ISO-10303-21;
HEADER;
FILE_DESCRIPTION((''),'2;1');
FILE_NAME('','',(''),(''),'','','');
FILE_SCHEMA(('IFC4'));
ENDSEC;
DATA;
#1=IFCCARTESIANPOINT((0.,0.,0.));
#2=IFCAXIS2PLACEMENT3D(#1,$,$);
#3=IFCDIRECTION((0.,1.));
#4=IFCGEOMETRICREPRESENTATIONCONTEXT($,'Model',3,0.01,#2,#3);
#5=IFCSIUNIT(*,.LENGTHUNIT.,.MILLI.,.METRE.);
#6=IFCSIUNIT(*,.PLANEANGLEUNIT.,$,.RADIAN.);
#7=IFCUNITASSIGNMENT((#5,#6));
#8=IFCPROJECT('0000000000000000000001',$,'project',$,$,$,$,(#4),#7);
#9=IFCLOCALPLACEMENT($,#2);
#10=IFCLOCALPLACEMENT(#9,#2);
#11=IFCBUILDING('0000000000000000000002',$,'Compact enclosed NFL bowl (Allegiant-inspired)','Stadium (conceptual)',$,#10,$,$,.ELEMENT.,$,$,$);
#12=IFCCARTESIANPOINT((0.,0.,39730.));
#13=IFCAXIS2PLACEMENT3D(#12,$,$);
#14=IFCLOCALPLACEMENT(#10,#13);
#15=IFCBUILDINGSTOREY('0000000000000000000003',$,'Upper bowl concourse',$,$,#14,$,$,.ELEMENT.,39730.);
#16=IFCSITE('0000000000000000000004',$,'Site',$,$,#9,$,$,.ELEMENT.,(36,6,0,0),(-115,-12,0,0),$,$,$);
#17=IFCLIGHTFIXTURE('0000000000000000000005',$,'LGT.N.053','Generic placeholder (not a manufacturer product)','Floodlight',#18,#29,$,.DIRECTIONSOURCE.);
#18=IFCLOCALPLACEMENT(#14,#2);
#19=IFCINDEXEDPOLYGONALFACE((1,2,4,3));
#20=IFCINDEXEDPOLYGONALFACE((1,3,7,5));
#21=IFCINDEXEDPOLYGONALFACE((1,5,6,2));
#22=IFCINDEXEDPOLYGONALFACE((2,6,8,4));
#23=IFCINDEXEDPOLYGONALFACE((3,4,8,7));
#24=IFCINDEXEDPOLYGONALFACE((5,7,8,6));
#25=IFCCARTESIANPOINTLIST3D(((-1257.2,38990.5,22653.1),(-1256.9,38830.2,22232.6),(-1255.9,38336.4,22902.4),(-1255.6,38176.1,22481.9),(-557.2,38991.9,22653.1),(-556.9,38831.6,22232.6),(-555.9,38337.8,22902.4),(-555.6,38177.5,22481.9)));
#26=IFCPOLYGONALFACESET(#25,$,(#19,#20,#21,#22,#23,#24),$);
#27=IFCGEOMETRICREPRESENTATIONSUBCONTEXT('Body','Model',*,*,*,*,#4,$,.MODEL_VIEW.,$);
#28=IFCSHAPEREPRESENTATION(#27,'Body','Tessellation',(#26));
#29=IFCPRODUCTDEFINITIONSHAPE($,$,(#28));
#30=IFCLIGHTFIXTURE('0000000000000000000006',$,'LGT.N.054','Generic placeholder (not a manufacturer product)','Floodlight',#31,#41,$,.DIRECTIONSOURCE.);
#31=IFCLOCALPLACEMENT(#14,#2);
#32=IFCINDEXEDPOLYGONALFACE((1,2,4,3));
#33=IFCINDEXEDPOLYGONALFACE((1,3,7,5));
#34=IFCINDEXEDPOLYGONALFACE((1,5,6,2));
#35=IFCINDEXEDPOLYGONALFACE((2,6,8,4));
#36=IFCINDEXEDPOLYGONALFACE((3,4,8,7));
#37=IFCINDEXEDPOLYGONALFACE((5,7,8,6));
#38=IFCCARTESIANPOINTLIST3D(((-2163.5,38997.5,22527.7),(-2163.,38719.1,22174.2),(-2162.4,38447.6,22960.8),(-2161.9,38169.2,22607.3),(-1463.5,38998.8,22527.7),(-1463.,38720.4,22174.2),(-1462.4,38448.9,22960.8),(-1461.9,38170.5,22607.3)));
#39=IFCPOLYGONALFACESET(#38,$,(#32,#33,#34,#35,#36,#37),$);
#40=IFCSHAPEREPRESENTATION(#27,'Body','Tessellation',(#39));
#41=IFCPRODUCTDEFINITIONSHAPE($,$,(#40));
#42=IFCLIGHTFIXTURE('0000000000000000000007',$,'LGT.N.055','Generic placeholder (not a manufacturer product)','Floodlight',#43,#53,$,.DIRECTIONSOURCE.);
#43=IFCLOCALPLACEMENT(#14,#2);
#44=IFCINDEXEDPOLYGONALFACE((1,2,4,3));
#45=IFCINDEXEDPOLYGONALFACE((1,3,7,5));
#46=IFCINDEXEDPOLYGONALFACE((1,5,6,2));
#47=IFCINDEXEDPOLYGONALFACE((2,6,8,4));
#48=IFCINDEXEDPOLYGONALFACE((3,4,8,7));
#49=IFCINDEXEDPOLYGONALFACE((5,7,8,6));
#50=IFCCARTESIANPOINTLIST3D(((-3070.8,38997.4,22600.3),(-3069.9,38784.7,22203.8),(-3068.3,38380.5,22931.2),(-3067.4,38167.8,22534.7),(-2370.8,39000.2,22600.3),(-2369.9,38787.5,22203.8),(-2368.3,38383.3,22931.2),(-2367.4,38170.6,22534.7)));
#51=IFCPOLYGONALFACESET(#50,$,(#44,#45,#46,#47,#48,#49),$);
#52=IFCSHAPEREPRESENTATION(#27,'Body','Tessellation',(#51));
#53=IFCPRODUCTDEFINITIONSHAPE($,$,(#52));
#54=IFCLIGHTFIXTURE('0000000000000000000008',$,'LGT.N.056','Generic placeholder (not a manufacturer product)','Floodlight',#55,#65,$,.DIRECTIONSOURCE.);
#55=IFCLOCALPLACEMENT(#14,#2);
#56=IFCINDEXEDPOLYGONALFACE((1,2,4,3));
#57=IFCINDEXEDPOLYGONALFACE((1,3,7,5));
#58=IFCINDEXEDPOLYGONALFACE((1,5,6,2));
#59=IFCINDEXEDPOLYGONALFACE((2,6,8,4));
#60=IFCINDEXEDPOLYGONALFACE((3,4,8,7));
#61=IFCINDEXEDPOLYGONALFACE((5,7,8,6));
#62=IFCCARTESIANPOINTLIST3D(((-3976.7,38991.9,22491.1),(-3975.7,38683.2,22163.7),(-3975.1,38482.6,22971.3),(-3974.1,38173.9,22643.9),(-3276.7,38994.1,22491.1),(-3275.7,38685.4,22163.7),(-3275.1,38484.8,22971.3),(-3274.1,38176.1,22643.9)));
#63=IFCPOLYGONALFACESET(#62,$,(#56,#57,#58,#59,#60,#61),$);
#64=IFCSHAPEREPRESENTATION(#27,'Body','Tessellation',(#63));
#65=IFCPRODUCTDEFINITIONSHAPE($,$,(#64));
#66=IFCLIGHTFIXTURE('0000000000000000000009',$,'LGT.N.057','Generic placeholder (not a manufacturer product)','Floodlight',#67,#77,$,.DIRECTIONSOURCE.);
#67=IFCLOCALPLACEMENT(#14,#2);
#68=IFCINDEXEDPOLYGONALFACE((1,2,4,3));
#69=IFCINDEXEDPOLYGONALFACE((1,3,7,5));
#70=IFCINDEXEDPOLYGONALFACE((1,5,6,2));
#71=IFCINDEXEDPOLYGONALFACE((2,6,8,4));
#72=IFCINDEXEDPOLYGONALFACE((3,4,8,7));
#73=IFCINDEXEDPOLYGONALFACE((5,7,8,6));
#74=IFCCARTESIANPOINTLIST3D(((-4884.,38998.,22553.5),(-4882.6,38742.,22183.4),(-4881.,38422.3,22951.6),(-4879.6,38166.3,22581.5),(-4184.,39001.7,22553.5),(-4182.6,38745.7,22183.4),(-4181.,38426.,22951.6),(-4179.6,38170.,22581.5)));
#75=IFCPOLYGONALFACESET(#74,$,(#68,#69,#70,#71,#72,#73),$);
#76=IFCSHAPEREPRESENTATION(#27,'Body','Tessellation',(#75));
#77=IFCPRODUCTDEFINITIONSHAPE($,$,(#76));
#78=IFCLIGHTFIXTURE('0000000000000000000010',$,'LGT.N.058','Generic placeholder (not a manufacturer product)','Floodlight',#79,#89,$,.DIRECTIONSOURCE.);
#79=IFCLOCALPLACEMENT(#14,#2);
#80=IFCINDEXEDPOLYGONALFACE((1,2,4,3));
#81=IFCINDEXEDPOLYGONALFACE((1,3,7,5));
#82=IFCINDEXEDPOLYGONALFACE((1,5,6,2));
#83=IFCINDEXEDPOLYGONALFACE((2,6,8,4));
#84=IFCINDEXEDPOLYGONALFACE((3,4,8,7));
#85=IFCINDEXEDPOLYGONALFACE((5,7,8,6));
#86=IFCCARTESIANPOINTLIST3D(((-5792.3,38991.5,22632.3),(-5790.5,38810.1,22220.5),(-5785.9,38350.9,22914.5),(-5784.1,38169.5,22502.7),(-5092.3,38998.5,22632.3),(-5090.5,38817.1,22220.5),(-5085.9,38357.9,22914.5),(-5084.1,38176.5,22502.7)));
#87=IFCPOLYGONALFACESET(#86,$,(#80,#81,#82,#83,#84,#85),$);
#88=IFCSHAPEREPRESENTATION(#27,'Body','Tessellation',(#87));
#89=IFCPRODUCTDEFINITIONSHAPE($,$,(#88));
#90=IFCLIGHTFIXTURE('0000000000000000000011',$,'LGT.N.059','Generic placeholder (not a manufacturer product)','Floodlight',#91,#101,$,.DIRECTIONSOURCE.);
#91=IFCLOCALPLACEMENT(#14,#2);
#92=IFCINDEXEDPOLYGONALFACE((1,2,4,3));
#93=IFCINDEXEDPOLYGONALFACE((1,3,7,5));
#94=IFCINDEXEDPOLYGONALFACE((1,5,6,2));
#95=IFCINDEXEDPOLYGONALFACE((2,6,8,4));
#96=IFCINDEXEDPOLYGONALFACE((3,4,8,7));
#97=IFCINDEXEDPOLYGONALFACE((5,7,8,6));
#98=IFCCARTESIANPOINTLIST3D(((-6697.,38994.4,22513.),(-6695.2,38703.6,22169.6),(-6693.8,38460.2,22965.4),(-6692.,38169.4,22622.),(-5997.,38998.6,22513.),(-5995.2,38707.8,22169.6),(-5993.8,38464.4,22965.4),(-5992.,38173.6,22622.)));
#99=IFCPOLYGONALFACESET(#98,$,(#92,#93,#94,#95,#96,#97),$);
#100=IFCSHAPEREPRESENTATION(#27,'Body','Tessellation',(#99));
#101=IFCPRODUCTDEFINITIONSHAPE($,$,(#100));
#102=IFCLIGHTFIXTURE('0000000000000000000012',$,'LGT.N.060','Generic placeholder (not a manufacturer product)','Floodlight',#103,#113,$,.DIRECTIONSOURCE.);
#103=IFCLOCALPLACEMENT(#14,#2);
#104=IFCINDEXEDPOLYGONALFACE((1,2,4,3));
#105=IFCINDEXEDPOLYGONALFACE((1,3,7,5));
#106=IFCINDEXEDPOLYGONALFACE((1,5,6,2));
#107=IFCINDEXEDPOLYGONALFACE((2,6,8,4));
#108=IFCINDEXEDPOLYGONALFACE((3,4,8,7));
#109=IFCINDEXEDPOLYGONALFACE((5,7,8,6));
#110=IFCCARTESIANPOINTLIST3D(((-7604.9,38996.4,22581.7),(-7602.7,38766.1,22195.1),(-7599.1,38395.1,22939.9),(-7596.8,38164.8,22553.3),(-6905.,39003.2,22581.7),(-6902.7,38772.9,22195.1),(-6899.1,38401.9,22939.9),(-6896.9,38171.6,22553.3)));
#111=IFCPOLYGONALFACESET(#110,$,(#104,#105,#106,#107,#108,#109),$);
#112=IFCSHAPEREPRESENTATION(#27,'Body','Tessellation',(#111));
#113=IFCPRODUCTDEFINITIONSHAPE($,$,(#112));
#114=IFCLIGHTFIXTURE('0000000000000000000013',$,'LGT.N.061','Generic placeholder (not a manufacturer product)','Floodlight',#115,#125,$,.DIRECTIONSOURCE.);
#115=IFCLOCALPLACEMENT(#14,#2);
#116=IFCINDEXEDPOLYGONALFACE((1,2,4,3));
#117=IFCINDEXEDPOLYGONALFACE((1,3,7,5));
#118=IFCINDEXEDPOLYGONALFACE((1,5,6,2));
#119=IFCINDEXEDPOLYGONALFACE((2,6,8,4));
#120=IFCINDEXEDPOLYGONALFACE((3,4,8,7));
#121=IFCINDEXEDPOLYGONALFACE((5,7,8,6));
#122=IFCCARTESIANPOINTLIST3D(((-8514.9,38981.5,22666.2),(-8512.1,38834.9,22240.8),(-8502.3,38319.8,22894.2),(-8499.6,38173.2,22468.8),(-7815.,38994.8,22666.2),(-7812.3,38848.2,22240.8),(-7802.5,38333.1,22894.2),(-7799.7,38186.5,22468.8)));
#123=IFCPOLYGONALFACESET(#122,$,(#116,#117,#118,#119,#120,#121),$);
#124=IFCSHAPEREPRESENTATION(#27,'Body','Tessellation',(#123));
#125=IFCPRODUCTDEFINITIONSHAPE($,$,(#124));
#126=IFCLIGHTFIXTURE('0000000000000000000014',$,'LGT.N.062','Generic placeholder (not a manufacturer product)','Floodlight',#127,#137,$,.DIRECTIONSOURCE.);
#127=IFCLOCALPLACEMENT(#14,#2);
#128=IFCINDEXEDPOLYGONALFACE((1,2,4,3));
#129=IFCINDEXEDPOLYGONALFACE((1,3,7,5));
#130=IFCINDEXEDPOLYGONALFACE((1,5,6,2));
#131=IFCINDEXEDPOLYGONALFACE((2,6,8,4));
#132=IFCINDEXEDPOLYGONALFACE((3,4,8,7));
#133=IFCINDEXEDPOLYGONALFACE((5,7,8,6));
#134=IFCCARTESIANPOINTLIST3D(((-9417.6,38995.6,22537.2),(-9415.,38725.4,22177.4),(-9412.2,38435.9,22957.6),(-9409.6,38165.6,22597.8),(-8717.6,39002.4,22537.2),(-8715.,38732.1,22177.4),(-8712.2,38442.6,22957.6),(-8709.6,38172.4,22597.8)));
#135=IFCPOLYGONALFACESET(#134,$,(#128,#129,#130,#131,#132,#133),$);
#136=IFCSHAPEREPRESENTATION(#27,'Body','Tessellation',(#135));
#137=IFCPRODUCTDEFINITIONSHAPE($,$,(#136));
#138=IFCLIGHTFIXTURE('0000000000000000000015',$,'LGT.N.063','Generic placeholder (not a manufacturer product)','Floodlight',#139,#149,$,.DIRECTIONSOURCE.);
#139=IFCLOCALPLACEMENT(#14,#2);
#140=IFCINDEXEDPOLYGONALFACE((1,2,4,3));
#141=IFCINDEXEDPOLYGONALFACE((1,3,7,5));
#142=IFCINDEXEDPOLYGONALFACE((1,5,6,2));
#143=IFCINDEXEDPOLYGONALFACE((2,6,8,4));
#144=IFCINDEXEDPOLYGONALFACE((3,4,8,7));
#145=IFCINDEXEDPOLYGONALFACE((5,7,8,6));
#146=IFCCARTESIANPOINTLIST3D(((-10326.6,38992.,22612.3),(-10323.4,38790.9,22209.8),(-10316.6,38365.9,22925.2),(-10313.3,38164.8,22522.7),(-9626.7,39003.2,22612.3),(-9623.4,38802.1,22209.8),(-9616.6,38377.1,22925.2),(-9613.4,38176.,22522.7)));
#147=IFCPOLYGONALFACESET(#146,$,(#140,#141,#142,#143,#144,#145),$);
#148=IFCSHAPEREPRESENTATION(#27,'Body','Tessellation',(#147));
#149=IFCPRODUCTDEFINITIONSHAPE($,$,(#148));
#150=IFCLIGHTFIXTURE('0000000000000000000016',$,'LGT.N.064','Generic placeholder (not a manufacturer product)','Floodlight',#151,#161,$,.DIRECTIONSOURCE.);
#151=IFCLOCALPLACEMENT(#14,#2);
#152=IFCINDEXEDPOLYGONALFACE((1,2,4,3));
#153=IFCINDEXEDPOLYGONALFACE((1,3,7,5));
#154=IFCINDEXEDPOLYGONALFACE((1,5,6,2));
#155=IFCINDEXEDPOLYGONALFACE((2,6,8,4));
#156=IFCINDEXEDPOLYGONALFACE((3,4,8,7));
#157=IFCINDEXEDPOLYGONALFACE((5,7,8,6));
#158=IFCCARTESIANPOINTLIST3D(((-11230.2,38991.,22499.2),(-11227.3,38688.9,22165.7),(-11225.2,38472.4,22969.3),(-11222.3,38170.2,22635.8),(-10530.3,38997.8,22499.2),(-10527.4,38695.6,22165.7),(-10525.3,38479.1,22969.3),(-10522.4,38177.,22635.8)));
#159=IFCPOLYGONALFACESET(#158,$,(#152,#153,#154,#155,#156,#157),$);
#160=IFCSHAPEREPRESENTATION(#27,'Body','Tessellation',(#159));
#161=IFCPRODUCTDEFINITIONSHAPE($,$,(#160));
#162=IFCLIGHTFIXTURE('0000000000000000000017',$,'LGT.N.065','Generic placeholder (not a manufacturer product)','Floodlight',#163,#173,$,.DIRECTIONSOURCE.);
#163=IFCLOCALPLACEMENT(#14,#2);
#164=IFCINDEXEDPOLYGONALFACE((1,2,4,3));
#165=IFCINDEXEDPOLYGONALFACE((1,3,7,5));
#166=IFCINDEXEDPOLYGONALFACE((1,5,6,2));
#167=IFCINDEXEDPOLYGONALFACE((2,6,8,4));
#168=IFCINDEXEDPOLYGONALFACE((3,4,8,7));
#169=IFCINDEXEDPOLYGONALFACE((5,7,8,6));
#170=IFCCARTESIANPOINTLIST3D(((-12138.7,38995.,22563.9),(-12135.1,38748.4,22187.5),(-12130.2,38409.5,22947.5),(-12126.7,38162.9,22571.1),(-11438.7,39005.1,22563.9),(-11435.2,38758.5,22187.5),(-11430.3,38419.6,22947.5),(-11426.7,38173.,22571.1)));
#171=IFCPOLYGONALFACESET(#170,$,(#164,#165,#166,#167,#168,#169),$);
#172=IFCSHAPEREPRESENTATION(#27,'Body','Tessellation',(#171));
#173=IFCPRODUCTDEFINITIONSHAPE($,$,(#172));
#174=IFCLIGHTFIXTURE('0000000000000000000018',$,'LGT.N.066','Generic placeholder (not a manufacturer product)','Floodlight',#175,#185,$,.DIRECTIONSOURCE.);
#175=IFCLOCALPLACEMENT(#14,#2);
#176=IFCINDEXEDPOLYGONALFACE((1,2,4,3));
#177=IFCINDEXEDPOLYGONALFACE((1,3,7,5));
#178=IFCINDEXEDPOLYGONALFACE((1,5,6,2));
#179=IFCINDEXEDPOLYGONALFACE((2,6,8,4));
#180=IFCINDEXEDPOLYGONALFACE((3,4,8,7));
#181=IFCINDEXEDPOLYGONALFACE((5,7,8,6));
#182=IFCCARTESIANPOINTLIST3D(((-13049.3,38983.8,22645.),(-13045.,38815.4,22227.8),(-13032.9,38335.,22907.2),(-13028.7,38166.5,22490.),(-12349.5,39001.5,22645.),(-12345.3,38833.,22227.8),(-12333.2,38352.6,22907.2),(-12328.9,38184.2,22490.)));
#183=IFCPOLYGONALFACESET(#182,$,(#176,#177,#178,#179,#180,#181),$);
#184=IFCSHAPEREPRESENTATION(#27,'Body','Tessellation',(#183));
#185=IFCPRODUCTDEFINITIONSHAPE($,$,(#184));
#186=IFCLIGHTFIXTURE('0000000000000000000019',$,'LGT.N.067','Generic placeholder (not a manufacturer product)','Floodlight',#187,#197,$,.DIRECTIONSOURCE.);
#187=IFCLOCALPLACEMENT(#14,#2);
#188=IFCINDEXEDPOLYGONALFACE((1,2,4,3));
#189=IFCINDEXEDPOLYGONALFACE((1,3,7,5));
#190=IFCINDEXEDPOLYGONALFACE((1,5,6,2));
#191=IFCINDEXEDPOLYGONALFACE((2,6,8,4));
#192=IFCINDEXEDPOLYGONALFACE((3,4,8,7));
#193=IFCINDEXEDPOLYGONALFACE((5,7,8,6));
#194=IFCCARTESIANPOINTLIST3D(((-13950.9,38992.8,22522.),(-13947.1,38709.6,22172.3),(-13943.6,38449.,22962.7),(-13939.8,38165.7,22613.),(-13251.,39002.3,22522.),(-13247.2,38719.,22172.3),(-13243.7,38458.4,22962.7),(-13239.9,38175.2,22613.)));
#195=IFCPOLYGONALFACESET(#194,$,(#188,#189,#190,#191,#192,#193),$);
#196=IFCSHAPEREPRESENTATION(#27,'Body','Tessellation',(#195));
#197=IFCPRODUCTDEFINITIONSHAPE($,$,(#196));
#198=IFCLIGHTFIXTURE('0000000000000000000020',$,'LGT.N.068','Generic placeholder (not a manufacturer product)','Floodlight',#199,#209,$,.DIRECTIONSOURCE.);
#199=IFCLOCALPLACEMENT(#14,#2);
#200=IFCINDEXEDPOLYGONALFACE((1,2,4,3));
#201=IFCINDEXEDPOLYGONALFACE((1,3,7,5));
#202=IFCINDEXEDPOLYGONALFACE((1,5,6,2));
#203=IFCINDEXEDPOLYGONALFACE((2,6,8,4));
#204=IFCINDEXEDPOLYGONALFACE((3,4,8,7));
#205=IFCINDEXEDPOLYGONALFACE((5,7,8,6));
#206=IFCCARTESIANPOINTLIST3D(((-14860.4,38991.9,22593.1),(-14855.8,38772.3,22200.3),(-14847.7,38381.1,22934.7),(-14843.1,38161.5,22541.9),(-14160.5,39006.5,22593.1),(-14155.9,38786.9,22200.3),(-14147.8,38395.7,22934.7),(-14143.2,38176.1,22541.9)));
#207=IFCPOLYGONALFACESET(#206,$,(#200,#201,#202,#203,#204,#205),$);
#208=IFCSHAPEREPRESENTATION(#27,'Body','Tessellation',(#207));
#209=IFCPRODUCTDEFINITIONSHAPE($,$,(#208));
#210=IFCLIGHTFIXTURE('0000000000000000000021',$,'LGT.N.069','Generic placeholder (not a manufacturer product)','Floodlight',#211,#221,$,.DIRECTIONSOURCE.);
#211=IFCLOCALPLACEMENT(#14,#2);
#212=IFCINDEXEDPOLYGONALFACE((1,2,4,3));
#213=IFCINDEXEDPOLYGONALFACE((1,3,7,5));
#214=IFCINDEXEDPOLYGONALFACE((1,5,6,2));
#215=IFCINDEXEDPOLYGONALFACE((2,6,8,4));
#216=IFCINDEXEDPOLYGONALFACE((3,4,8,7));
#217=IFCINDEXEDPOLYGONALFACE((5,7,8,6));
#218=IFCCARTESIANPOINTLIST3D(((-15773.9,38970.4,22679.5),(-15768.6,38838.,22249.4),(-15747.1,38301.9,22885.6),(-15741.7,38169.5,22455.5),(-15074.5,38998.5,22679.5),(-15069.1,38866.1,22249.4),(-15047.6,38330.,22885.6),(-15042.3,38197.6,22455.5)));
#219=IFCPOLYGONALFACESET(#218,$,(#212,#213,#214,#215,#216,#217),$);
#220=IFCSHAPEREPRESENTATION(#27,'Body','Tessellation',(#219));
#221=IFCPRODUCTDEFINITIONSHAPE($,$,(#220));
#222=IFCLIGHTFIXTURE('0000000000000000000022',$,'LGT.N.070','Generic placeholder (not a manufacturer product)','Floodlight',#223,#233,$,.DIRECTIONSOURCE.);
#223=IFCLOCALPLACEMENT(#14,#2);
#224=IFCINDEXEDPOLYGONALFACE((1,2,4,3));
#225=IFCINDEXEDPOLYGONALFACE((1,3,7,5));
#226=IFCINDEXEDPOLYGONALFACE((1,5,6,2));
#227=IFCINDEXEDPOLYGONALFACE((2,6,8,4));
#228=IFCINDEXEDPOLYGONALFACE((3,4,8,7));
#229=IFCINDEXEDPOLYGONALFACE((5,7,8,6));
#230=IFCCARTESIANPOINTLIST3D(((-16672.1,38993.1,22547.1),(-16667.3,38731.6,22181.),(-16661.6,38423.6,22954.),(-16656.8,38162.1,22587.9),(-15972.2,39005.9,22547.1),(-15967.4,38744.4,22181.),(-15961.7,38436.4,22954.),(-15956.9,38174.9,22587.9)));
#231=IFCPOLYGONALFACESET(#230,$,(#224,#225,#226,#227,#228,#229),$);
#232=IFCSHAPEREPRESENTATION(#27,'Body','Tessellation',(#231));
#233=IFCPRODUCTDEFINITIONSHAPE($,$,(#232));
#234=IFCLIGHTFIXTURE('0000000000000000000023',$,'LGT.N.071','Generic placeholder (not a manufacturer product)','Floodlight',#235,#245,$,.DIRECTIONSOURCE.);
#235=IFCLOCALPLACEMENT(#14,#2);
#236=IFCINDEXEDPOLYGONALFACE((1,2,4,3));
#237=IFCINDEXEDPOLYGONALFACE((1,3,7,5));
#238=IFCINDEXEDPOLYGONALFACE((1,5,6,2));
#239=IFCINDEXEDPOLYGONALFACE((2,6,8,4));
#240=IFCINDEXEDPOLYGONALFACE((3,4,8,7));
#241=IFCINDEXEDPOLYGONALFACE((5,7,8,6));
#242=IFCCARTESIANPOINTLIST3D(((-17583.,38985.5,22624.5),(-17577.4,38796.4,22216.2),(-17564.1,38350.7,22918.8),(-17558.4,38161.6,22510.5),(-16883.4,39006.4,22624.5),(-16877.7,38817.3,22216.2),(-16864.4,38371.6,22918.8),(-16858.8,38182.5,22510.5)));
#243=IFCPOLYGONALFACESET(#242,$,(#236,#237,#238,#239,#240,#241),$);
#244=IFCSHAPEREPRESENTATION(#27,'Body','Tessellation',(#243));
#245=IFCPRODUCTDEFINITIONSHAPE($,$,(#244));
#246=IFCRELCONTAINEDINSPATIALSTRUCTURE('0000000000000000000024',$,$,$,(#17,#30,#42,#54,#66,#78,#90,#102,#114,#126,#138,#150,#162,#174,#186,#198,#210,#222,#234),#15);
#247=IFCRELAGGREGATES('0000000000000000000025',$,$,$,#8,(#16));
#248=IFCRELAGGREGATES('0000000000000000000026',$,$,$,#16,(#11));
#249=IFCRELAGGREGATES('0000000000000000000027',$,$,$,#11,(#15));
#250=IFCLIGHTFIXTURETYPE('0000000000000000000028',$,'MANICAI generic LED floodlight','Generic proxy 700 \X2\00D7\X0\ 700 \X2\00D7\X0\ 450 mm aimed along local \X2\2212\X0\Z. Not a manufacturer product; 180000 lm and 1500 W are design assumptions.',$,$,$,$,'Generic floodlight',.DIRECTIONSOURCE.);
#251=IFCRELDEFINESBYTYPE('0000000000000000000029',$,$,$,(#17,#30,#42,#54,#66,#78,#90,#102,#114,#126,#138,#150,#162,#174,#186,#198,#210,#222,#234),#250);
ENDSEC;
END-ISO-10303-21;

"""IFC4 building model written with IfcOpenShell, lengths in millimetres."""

from ifc_helpers import new_model, si_unit, direction, frame, origin, place, context, subcontext, project, spatial, rectangle, extrude, source, transform, mapped, type_object, type_shapes, element, save


model = new_model("IFC4")

# Units and contexts
model_context = context("Model", 3, precision=0.01, world=origin(), true_north=direction((0.0, 1.0)))
body_context = subcontext(model_context, "Body", "Model", "MODEL_VIEW")
ifc_project = project(units=[si_unit("LENGTHUNIT", "METRE", prefix="MILLI"), si_unit("PLANEANGLEUNIT", "RADIAN")], contexts=[model_context])

# Site, building, storey
site_placement = place(None, origin())
site = spatial("IfcSite", under=ifc_project, at=site_placement, Name="Site", CompositionType="ELEMENT", RefLatitude=(36, 6, 0, 0), RefLongitude=(-115, -12, 0, 0))
building_placement = place(site_placement, origin())
building = spatial("IfcBuilding", under=site, at=building_placement, Name="Compact enclosed NFL bowl (Allegiant-inspired)", Description="Stadium (conceptual)", CompositionType="ELEMENT")
storey_placement = place(building_placement, frame((0.0, 0.0, 39730.0)))
storey = spatial("IfcBuildingStorey", under=building, at=storey_placement, Name="Upper bowl concourse", CompositionType="ELEMENT", Elevation=39730.0)

# Light fixtures
light_fixture_type = type_object("IfcLightFixtureType", Name="MANICAI generic LED floodlight", Description="Generic proxy 700 × 700 × 450 mm aimed along local −Z. Not a manufacturer product; 180000 lm and 1500 W are design assumptions.", ElementType="Generic floodlight", PredefinedType="DIRECTIONSOURCE")
shared_shape = source(origin(), body_context, "Body", "SweptSolid", [
    extrude(rectangle(XDim=700.0, YDim=700.0), frame((0.0, 0.0, -225.0)), (0.0, 0.0, 1.0), 450.0),
])
type_shapes(light_fixture_type, [shared_shape])
for number, where, z_axis, x_axis, name in (
    (1, (-906.4, 38584.0, 22567.5), (-0.00068, 0.356162, 0.934424), (-0.999998, -0.001909, 0.0), "LGT.N.053"),
    (2, (-1812.7, 38584.0, 22567.5), (-0.001143, 0.618717, 0.785613), (-0.999998, -0.001847, 0.0), "LGT.N.054"),
    (3, (-2719.1, 38584.0, 22567.5), (-0.001923, 0.472682, 0.881231), (-0.999992, -0.004069, 0.0), "LGT.N.055"),
    (4, (-3625.4, 38584.0, 22567.5), (-0.002117, 0.685986, 0.727612), (-0.999995, -0.003086, 0.0), "LGT.N.056"),
    (5, (-4531.8, 38584.0, 22567.5), (-0.002991, 0.568825, 0.822453), (-0.999986, -0.005259, 0.0), "LGT.N.057"),
    (6, (-5438.2, 38584.0, 22567.5), (-0.003994, 0.40308, 0.915156), (-0.999951, -0.009909, 0.0), "LGT.N.058"),
    (7, (-6344.5, 38584.0, 22567.5), (-0.003886, 0.646248, 0.763118), (-0.999982, -0.006013, 0.0), "LGT.N.059"),
    (8, (-7250.9, 38584.0, 22567.5), (-0.005, 0.511759, 0.859115), (-0.999952, -0.009769, 0.0), "LGT.N.060"),
    (9, (-8157.3, 38584.0, 22567.5), (-0.00619, 0.325717, 0.945447), (-0.999819, -0.019, 0.0), "LGT.N.061"),
    (10, (-9063.6, 38584.0, 22567.5), (-0.005817, 0.600457, 0.799636), (-0.999953, -0.009687, 0.0), "LGT.N.062"),
    (11, (-9970.0, 38584.0, 22567.5), (-0.007158, 0.447018, 0.894496), (-0.999872, -0.01601, 0.0), "LGT.N.063"),
    (12, (-10876.3, 38584.0, 22567.5), (-0.006469, 0.671463, 0.74101), (-0.999954, -0.009633, 0.0), "LGT.N.064"),
    (13, (-11782.7, 38584.0, 22567.5), (-0.007911, 0.547894, 0.836511), (-0.999896, -0.014437, 0.0), "LGT.N.065"),
    (14, (-12689.1, 38584.0, 22567.5), (-0.009443, 0.374413, 0.927214), (-0.999682, -0.025213, 0.0), "LGT.N.066"),
    (15, (-13595.4, 38584.0, 22567.5), (-0.008478, 0.629496, 0.776957), (-0.999909, -0.013467, 0.0), "LGT.N.067"),
    (16, (-14501.8, 38584.0, 22567.5), (-0.010159, 0.487938, 0.872819), (-0.999783, -0.020815, 0.0), "LGT.N.068"),
    (17, (-15408.1, 38584.0, 22567.5), (-0.011818, 0.294217, 0.955666), (-0.999194, -0.040136, 0.0), "LGT.N.069"),
    (18, (-16314.5, 38584.0, 22567.5), (-0.010655, 0.581196, 0.813694), (-0.999832, -0.018329, 0.0), "LGT.N.070"),
    (19, (-17220.9, 38584.0, 22567.5), (-0.012541, 0.420191, 0.907349), (-0.999555, -0.029832, 0.0), "LGT.N.071"),
):
    element("IfcLightFixture", number, at=place(storey_placement, frame(where, z_axis=z_axis, x_axis=x_axis)), inside=storey, type_object=light_fixture_type, Name=name, Description="Generic placeholder (not a manufacturer product)", ObjectType="Floodlight", PredefinedType="DIRECTIONSOURCE", context=body_context, shape_type="MappedRepresentation", body=[
        mapped(shared_shape, transform((0.0, 0.0, 0.0))),
    ])

save(model, "model.ifc")
